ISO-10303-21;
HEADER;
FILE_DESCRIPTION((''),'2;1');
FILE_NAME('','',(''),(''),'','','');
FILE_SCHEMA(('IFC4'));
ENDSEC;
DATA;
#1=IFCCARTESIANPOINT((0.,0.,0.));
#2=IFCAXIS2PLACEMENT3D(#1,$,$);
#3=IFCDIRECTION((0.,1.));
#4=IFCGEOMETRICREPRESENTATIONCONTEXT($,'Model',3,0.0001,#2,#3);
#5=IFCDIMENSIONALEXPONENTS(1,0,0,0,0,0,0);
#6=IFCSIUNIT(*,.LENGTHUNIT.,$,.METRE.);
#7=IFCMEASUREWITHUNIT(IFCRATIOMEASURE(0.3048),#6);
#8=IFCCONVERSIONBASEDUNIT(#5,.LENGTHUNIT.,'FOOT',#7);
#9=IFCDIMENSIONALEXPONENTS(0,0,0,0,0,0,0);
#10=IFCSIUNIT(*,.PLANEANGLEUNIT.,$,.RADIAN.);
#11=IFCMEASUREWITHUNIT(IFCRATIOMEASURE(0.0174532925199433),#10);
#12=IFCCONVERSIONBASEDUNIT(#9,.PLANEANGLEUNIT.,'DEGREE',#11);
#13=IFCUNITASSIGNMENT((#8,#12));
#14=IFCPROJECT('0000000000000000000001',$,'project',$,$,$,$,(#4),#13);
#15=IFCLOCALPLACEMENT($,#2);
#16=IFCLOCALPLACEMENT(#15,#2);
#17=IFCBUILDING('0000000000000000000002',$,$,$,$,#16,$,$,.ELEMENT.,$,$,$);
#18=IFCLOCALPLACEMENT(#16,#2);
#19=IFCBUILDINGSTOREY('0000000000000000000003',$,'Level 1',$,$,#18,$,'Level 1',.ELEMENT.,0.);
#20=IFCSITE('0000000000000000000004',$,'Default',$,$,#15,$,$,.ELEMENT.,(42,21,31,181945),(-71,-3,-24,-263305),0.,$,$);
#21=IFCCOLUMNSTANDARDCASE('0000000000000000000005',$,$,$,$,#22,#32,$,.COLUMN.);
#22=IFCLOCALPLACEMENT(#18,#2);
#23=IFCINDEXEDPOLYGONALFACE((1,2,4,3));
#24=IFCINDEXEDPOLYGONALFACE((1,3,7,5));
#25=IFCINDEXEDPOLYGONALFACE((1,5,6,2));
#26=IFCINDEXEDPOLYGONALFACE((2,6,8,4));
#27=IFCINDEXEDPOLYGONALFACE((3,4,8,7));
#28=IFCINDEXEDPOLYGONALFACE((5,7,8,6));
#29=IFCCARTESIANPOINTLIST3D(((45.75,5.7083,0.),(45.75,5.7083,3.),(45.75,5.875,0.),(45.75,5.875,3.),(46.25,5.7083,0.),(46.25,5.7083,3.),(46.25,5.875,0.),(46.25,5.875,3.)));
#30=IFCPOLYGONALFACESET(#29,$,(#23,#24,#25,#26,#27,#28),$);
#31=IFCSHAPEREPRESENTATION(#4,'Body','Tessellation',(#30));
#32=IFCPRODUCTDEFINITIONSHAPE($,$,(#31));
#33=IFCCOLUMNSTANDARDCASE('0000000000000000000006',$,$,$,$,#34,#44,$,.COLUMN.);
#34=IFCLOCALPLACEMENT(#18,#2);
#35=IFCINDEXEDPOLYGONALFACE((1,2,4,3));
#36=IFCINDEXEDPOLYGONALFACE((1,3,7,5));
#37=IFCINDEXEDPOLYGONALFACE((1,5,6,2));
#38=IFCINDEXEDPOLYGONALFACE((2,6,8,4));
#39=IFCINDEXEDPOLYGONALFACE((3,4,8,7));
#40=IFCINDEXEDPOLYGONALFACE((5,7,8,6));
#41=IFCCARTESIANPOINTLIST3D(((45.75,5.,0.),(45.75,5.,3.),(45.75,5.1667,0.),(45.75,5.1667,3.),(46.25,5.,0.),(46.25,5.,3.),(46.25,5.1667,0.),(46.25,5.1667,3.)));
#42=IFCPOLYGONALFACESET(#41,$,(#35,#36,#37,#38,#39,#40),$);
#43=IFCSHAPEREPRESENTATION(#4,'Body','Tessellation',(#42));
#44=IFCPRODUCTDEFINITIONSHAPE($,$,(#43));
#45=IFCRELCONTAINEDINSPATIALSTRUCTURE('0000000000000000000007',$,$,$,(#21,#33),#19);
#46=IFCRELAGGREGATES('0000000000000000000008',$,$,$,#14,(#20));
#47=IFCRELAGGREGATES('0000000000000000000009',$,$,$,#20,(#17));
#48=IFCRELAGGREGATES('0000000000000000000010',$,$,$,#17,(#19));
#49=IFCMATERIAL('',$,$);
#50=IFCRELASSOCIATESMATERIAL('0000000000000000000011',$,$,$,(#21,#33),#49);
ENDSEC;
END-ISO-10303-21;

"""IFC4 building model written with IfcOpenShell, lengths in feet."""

from ifc_helpers import new_model, entity, si_unit, converted_unit, direction, frame, origin, place, context, project, spatial, rectangle, extrude, material, element, save


model = new_model("IFC4")

# Units and contexts
model_context = context("Model", 3, precision=0.0001, world=origin(), true_north=direction((0.0, 1.0)))
ifc_project = project(units=[converted_unit("LENGTHUNIT", "FOOT", entity("IfcRatioMeasure", 0.3048), si_unit("LENGTHUNIT", "METRE"), dimensions=[1, 0, 0, 0, 0, 0, 0]), converted_unit("PLANEANGLEUNIT", "DEGREE", entity("IfcRatioMeasure", 0.0174532925199433), si_unit("PLANEANGLEUNIT", "RADIAN"), dimensions=[0, 0, 0, 0, 0, 0, 0])], contexts=[model_context])

# Site, building, storey
site_placement = place(None, origin())
site = spatial("IfcSite", under=ifc_project, at=site_placement, Name="Default", CompositionType="ELEMENT", RefLatitude=(42, 21, 31, 181945), RefLongitude=(-71, -3, -24, -263305), RefElevation=0.0)
building_placement = place(site_placement, origin())
building = spatial("IfcBuilding", under=site, at=building_placement, CompositionType="ELEMENT")
storey_placement = place(building_placement, origin())
storey = spatial("IfcBuildingStorey", under=building, at=storey_placement, Name="Level 1", LongName="Level 1", CompositionType="ELEMENT", Elevation=0.0)

# Columns
placement = place(storey_placement, frame((46.0, 46.25, 0.0), z_axis=(0.0, 0.0, 1.0), x_axis=(0.0, -1.0, 0.0)))
ifc_material_1 = material(Name="")
for number, where, z_axis, x_axis in (
    (1, (40.4583, 0.0, 0.0), (0.0, 0.0, 1.0), (1.0, 0.0, 0.0)),
    (2, (41.1667, 0.0, 0.0), (0.0, 0.0, 1.0), (1.0, 0.0, 0.0)),
):
    element("IfcColumnStandardCase", number, at=place(placement, frame(where, z_axis=z_axis, x_axis=x_axis)), inside=storey, material=ifc_material_1, PredefinedType="COLUMN", context=model_context, shape_type="SweptSolid", body=[
        extrude(rectangle(XDim=0.1667, YDim=0.5), origin(), (0.0, 0.0, 1.0), 3.0),
    ])

save(model, "model.ifc")
